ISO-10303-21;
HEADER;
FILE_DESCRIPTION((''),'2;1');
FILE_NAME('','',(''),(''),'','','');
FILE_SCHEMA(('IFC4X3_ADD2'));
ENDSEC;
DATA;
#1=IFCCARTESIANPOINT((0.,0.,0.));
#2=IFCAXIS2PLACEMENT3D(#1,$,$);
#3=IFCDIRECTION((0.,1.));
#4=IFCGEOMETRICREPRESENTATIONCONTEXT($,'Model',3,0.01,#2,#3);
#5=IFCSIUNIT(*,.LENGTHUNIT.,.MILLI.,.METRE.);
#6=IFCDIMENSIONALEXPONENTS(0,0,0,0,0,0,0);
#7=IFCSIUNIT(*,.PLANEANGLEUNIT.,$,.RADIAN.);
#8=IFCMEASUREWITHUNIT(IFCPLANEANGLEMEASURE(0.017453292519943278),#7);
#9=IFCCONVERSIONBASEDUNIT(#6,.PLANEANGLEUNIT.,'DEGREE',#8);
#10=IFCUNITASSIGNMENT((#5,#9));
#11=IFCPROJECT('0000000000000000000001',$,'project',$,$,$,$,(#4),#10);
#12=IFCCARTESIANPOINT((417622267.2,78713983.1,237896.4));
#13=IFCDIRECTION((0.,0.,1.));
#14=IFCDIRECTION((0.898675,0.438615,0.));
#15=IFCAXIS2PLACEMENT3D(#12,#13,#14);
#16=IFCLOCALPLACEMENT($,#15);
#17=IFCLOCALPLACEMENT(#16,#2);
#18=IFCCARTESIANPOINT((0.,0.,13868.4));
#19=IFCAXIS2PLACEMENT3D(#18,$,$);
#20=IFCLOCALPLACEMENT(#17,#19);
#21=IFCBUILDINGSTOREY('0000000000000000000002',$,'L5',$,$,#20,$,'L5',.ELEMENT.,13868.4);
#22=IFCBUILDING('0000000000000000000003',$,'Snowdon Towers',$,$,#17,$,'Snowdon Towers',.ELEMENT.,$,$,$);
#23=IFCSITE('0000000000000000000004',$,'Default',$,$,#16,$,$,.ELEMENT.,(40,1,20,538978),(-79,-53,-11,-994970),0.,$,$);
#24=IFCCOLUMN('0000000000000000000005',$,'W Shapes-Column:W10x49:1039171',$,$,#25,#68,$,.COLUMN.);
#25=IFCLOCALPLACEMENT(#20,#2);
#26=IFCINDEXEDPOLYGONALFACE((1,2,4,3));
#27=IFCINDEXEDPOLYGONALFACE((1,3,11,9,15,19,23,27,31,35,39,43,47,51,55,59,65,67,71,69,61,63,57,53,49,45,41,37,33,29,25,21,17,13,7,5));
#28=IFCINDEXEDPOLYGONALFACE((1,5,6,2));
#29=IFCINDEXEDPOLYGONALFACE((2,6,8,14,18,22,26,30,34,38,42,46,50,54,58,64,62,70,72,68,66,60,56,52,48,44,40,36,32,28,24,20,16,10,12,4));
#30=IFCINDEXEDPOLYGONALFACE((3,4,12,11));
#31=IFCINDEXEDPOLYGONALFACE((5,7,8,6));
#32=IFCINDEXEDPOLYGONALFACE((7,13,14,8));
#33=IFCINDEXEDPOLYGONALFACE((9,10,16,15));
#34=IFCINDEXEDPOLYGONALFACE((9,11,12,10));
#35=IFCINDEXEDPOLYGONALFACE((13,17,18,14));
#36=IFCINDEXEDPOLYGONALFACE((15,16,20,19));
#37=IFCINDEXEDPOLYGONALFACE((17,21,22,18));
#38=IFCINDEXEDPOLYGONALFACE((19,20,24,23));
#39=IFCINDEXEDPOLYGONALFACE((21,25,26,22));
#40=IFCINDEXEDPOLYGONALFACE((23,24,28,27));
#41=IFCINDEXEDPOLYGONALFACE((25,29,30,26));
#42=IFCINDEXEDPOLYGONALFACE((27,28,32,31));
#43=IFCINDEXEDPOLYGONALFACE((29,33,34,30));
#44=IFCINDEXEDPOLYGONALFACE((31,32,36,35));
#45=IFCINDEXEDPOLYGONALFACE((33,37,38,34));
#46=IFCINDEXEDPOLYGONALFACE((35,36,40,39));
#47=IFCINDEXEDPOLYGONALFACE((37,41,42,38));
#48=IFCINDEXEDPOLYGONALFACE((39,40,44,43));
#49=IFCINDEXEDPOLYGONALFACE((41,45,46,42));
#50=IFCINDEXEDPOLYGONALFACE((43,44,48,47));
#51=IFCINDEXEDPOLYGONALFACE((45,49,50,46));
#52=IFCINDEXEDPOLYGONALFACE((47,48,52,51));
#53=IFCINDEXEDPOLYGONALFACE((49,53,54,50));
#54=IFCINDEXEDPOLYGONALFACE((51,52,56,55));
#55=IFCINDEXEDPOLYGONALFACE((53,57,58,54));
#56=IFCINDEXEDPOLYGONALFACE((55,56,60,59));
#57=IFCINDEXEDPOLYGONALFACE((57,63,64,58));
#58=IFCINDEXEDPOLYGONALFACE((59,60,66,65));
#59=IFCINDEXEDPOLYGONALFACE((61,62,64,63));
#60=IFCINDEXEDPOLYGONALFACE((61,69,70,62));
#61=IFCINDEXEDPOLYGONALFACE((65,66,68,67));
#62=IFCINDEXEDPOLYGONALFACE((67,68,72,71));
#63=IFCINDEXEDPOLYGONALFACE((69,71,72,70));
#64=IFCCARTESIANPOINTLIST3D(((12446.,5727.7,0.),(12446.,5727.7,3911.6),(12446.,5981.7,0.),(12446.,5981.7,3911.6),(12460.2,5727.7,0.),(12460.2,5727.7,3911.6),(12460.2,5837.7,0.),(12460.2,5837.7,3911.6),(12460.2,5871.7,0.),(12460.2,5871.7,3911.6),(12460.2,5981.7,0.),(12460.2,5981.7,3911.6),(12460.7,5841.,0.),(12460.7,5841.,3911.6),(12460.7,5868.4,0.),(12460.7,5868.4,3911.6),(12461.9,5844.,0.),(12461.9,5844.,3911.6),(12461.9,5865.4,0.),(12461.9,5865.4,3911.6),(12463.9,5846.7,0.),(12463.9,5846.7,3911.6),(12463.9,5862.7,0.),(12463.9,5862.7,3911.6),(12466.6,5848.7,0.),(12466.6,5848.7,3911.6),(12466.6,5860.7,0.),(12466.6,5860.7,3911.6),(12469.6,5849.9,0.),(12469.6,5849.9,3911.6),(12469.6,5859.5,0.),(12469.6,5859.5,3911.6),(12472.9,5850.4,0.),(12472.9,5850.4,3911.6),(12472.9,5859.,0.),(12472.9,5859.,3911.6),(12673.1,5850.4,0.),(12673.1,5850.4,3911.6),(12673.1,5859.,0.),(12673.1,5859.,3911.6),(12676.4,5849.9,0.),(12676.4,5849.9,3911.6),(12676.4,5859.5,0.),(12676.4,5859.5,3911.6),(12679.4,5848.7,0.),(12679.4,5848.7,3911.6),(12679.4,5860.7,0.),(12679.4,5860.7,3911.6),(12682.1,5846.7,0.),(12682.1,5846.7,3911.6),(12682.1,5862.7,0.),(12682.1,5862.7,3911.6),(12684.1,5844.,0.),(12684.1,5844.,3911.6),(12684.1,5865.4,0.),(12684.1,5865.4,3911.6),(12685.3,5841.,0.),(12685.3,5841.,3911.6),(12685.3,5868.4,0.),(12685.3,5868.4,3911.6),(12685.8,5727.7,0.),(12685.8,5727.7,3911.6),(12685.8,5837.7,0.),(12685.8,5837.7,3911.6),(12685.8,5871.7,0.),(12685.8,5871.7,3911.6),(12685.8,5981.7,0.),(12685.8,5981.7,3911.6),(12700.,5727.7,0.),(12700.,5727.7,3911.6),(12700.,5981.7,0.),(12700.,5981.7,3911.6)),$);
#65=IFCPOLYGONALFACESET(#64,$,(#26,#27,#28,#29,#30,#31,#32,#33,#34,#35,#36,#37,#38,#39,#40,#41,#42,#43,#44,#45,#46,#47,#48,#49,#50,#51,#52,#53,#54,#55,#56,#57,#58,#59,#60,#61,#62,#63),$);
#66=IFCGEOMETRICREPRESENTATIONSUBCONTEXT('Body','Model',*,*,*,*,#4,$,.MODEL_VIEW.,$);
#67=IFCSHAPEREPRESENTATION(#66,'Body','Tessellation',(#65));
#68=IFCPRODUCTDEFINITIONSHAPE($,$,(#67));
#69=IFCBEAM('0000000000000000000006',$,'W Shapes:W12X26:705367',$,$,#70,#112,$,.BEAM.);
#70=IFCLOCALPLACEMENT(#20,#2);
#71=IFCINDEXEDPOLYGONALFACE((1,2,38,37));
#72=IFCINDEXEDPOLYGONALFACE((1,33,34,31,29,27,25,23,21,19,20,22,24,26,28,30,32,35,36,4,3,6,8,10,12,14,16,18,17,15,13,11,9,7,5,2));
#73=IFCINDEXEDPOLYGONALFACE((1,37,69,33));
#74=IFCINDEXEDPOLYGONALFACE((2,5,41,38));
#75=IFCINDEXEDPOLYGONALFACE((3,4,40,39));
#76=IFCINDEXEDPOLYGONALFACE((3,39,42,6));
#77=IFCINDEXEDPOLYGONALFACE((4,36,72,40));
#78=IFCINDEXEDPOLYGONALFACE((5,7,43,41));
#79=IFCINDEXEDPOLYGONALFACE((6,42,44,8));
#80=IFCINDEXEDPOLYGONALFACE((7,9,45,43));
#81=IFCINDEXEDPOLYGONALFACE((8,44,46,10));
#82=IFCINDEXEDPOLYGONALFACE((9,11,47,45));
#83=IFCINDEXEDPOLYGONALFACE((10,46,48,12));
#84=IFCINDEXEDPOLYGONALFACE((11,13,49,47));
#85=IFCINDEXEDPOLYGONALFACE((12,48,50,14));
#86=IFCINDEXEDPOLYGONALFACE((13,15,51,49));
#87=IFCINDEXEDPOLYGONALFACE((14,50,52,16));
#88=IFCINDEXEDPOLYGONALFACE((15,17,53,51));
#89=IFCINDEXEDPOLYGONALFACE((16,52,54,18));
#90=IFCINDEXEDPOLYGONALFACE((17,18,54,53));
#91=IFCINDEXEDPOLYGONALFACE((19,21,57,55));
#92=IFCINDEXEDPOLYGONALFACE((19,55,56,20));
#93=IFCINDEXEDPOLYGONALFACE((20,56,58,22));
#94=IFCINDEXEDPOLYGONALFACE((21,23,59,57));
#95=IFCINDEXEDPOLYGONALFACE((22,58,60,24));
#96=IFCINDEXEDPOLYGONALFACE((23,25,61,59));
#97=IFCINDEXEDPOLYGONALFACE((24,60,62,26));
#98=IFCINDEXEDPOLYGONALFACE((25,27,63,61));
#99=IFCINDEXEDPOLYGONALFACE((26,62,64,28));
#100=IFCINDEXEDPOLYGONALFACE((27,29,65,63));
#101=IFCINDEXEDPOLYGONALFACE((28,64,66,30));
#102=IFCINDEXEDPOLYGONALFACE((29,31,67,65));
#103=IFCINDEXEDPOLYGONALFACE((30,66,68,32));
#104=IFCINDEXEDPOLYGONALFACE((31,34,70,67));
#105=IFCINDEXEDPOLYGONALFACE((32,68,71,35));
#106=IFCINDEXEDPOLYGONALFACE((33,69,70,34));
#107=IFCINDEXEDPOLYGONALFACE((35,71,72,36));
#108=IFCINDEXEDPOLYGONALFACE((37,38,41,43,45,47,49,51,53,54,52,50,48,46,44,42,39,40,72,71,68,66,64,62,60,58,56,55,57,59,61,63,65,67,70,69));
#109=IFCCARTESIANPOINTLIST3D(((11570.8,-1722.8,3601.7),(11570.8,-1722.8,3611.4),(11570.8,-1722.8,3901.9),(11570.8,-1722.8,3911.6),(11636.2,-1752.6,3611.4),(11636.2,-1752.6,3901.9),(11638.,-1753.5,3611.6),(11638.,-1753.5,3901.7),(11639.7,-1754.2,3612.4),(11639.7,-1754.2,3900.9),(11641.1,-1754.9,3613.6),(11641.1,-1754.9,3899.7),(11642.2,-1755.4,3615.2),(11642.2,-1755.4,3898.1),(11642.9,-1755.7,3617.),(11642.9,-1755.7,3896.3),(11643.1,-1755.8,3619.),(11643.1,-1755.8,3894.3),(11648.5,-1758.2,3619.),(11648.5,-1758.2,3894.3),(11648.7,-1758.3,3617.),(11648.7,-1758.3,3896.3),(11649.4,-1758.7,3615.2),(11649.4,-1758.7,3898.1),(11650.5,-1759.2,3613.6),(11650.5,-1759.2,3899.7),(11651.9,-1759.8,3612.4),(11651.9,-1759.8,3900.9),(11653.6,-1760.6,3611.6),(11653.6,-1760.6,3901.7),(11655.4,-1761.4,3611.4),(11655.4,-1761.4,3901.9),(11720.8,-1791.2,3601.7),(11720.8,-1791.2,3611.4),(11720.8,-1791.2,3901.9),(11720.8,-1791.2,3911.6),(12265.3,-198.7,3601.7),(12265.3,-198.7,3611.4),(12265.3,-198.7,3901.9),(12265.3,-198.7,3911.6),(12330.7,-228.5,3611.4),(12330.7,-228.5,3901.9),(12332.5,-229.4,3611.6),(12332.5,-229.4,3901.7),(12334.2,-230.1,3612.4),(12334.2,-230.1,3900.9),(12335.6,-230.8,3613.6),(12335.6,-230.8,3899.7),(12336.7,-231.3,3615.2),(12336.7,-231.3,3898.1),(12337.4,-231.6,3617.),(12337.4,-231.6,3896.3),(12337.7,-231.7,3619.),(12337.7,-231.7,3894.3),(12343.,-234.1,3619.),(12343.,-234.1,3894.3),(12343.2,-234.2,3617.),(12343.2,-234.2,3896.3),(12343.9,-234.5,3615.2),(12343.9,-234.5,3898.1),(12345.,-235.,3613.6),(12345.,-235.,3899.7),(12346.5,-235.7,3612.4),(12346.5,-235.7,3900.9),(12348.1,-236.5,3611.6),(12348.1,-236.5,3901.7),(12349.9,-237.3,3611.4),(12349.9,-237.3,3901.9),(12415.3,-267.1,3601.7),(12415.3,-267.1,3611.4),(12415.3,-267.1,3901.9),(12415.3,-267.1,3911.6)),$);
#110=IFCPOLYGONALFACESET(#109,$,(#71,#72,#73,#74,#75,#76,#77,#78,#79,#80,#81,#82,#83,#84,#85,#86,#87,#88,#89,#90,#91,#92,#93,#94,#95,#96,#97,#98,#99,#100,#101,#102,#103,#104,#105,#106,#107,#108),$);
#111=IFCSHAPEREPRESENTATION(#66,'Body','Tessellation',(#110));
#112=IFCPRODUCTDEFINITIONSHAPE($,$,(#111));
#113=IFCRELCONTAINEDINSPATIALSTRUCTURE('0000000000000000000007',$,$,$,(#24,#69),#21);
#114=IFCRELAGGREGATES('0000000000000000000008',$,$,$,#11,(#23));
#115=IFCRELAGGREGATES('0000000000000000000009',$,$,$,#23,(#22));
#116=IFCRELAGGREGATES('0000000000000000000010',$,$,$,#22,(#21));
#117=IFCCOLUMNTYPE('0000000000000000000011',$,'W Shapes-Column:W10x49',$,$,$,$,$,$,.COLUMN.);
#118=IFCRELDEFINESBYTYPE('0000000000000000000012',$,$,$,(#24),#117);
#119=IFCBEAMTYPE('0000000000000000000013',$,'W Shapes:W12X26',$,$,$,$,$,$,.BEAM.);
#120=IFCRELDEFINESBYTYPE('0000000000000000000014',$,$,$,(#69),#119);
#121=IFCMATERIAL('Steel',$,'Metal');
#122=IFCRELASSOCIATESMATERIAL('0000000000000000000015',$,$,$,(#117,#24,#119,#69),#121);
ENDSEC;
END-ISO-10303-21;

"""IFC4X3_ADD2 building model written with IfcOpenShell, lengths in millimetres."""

from ifc_helpers import new_model, entity, si_unit, converted_unit, direction, frame, frame_2d, origin, place, context, subcontext, project, spatial, polyline, circle_curve, parameter, trimmed, segment, composite_curve, i_section, outline, extrude, source, transform, mapped, material, material_profile, profile_set, profile_usage, type_object, type_shapes, element, save


model = new_model("IFC4X3_ADD2")

# Units and contexts
model_context = context("Model", 3, precision=0.01, world=origin(), true_north=direction((0.0, 1.0)))
body_context = subcontext(model_context, "Body", "Model", "MODEL_VIEW")
ifc_project = project(units=[si_unit("LENGTHUNIT", "METRE", prefix="MILLI"), converted_unit("PLANEANGLEUNIT", "DEGREE", entity("IfcPlaneAngleMeasure", 0.017453292519943278), si_unit("PLANEANGLEUNIT", "RADIAN"), dimensions=[0, 0, 0, 0, 0, 0, 0])], contexts=[model_context])

# Site, building, storey
site_placement = place(None, frame((417622267.2, 78713983.1, 237896.4), z_axis=(0.0, 0.0, 1.0), x_axis=(0.898675, 0.438615, 0.0)))
site = spatial("IfcSite", under=ifc_project, at=site_placement, Name="Default", CompositionType="ELEMENT", RefLatitude=(40, 1, 20, 538978), RefLongitude=(-79, -53, -11, -994970), RefElevation=0.0)
building_placement = place(site_placement, origin())
building = spatial("IfcBuilding", under=site, at=building_placement, Name="Snowdon Towers", LongName="Snowdon Towers", CompositionType="ELEMENT")
storey_placement = place(building_placement, frame((0.0, 0.0, 13868.4)))
storey = spatial("IfcBuildingStorey", under=building, at=storey_placement, Name="L5", LongName="L5", CompositionType="ELEMENT", Elevation=13868.4)

# Column
ifc_material_1 = material(Name="Steel", Category="Metal")
ifc_material_profile_1 = material_profile(ifc_material_1, i_section(OverallWidth=254.0, OverallDepth=254.0, WebThickness=8.6, FlangeThickness=14.2, FilletRadius=12.7, at=frame_2d((0.0, 0.0), x_axis=(1.0, 0.0))), Name="W10x49")
ifc_profile_set_1 = profile_set([ifc_material_profile_1], Name="W10x49")
ifc_profile_usage_1 = profile_usage(ifc_profile_set_1)
column_type_1 = type_object("IfcColumnType", Name="W Shapes-Column:W10x49", PredefinedType="COLUMN", material=ifc_profile_set_1)
shared_shape_1 = source(origin(), body_context, "Body", "SweptSolid", [
    extrude(i_section(OverallWidth=254.0, OverallDepth=254.0, WebThickness=8.6, FlangeThickness=14.2, FilletRadius=12.7, at=frame_2d((0.0, 0.0), x_axis=(1.0, 0.0))), frame((0.0, 0.0, 13868.4), z_axis=(0.0, 0.0, 1.0), x_axis=(-1.0, 0.0, 0.0)), (0.0, 0.0, 1.0), 3911.6),
])
type_shapes(column_type_1, [shared_shape_1])
column_1_placement = place(storey_placement, frame((12573.0, 5854.7, -13868.4), z_axis=(0.0, 0.0, 1.0), x_axis=(0.0, 1.0, 0.0)))
element("IfcColumn", 1, at=column_1_placement, inside=storey, type_object=column_type_1, material=ifc_profile_usage_1, Name="W Shapes-Column:W10x49:1039171", PredefinedType="COLUMN", context=body_context, shape_type="MappedRepresentation", body=[
    mapped(shared_shape_1, transform((0.0, 0.0, 0.0), scale=1.0)),
])

# Beam
ifc_material_profile_2 = material_profile(ifc_material_1, outline(composite_curve([segment(polyline([(-82.4, -145.3), (-82.4, -154.9)]), True, "CONTINUOUS"), segment(polyline([(-82.4, -154.9), (82.4, -154.9)]), True, "CONTINUOUS"), segment(polyline([(82.4, -154.9), (82.4, -145.3)]), True, "CONTINUOUS"), segment(polyline([(82.4, -145.3), (10.5, -145.3)]), True, "CONTINUOUS"), segment(trimmed(circle_curve(frame_2d((10.5, -137.7), x_axis=(1.0, 0.0)), 7.6), [parameter(180.0)], [parameter(270.0)], True, "PARAMETER"), False, "CONTINUOUS"), segment(polyline([(2.9, -137.7), (2.9, 137.7)]), True, "CONTINUOUS"), segment(trimmed(circle_curve(frame_2d((10.5, 137.7), x_axis=(1.0, 0.0)), 7.6), [parameter(90.0)], [parameter(180.0)], True, "PARAMETER"), False, "CONTINUOUS"), segment(polyline([(10.5, 145.3), (82.4, 145.3)]), True, "CONTINUOUS"), segment(polyline([(82.4, 145.3), (82.4, 154.9)]), True, "CONTINUOUS"), segment(polyline([(82.4, 154.9), (-82.4, 154.9)]), True, "CONTINUOUS"), segment(polyline([(-82.4, 154.9), (-82.4, 145.3)]), True, "CONTINUOUS"), segment(polyline([(-82.4, 145.3), (-10.5, 145.3)]), True, "CONTINUOUS"), segment(trimmed(circle_curve(frame_2d((-10.5, 137.7), x_axis=(1.0, 0.0)), 7.6), [parameter(360.0)], [parameter(90.0)], True, "PARAMETER"), False, "CONTINUOUS"), segment(polyline([(-2.9, 137.7), (-2.9, -137.7)]), True, "CONTINUOUS"), segment(trimmed(circle_curve(frame_2d((-10.5, -137.7), x_axis=(1.0, 0.0)), 7.6), [parameter(270.0)], [parameter(360.0)], True, "PARAMETER"), False, "CONTINUOUS"), segment(polyline([(-10.5, -145.3), (-82.4, -145.3)]), True, "CONTINUOUS")], self_intersect=False)), Name="W12X26")
ifc_profile_set_2 = profile_set([ifc_material_profile_2], Name="W12X26")
ifc_profile_usage_2 = profile_usage(ifc_profile_set_2, cardinal=8)
beam_type_1 = type_object("IfcBeamType", Name="W Shapes:W12X26", PredefinedType="BEAM", material=ifc_profile_set_2)
shared_shape_2 = source(origin(), body_context, "Body", "SweptSolid", [
    extrude(outline(composite_curve([segment(polyline([(-82.4, -145.3), (-82.4, -154.9)]), True, "CONTINUOUS"), segment(polyline([(-82.4, -154.9), (82.4, -154.9)]), True, "CONTINUOUS"), segment(polyline([(82.4, -154.9), (82.4, -145.3)]), True, "CONTINUOUS"), segment(polyline([(82.4, -145.3), (10.5, -145.3)]), True, "CONTINUOUS"), segment(trimmed(circle_curve(frame_2d((10.5, -137.7), x_axis=(1.0, 0.0)), 7.6), [parameter(180.0)], [parameter(270.0)], True, "PARAMETER"), False, "CONTINUOUS"), segment(polyline([(2.9, -137.7), (2.9, 137.7)]), True, "CONTINUOUS"), segment(trimmed(circle_curve(frame_2d((10.5, 137.7), x_axis=(1.0, 0.0)), 7.6), [parameter(90.0)], [parameter(180.0)], True, "PARAMETER"), False, "CONTINUOUS"), segment(polyline([(10.5, 145.3), (82.4, 145.3)]), True, "CONTINUOUS"), segment(polyline([(82.4, 145.3), (82.4, 154.9)]), True, "CONTINUOUS"), segment(polyline([(82.4, 154.9), (-82.4, 154.9)]), True, "CONTINUOUS"), segment(polyline([(-82.4, 154.9), (-82.4, 145.3)]), True, "CONTINUOUS"), segment(polyline([(-82.4, 145.3), (-10.5, 145.3)]), True, "CONTINUOUS"), segment(trimmed(circle_curve(frame_2d((-10.5, 137.7), x_axis=(1.0, 0.0)), 7.6), [parameter(360.0)], [parameter(90.0)], True, "PARAMETER"), False, "CONTINUOUS"), segment(polyline([(-2.9, 137.7), (-2.9, -137.7)]), True, "CONTINUOUS"), segment(trimmed(circle_curve(frame_2d((-10.5, -137.7), x_axis=(1.0, 0.0)), 7.6), [parameter(270.0)], [parameter(360.0)], True, "PARAMETER"), False, "CONTINUOUS"), segment(polyline([(-10.5, -145.3), (-82.4, -145.3)]), True, "CONTINUOUS")], self_intersect=False)), frame((-1060.8, 0.0, 0.0), z_axis=(-1.0, 0.0, 0.0), x_axis=(0.0, -1.0, 0.0)), (0.0, 0.0, -1.0), 1674.9),
])
type_shapes(beam_type_1, [shared_shape_2])
beam_1_placement = place(storey_placement, frame((12085.7, -791.7, 3756.7), z_axis=(0.0, 0.0, 1.0), x_axis=(0.414671, 0.909972, 0.0)))
element("IfcBeam", 2, at=beam_1_placement, inside=storey, type_object=beam_type_1, material=ifc_profile_usage_2, Name="W Shapes:W12X26:705367", PredefinedType="BEAM", context=body_context, shape_type="MappedRepresentation", body=[
    mapped(shared_shape_2, transform((0.0, 0.0, 0.0), scale=1.0)),
])

save(model, "model.ifc")
